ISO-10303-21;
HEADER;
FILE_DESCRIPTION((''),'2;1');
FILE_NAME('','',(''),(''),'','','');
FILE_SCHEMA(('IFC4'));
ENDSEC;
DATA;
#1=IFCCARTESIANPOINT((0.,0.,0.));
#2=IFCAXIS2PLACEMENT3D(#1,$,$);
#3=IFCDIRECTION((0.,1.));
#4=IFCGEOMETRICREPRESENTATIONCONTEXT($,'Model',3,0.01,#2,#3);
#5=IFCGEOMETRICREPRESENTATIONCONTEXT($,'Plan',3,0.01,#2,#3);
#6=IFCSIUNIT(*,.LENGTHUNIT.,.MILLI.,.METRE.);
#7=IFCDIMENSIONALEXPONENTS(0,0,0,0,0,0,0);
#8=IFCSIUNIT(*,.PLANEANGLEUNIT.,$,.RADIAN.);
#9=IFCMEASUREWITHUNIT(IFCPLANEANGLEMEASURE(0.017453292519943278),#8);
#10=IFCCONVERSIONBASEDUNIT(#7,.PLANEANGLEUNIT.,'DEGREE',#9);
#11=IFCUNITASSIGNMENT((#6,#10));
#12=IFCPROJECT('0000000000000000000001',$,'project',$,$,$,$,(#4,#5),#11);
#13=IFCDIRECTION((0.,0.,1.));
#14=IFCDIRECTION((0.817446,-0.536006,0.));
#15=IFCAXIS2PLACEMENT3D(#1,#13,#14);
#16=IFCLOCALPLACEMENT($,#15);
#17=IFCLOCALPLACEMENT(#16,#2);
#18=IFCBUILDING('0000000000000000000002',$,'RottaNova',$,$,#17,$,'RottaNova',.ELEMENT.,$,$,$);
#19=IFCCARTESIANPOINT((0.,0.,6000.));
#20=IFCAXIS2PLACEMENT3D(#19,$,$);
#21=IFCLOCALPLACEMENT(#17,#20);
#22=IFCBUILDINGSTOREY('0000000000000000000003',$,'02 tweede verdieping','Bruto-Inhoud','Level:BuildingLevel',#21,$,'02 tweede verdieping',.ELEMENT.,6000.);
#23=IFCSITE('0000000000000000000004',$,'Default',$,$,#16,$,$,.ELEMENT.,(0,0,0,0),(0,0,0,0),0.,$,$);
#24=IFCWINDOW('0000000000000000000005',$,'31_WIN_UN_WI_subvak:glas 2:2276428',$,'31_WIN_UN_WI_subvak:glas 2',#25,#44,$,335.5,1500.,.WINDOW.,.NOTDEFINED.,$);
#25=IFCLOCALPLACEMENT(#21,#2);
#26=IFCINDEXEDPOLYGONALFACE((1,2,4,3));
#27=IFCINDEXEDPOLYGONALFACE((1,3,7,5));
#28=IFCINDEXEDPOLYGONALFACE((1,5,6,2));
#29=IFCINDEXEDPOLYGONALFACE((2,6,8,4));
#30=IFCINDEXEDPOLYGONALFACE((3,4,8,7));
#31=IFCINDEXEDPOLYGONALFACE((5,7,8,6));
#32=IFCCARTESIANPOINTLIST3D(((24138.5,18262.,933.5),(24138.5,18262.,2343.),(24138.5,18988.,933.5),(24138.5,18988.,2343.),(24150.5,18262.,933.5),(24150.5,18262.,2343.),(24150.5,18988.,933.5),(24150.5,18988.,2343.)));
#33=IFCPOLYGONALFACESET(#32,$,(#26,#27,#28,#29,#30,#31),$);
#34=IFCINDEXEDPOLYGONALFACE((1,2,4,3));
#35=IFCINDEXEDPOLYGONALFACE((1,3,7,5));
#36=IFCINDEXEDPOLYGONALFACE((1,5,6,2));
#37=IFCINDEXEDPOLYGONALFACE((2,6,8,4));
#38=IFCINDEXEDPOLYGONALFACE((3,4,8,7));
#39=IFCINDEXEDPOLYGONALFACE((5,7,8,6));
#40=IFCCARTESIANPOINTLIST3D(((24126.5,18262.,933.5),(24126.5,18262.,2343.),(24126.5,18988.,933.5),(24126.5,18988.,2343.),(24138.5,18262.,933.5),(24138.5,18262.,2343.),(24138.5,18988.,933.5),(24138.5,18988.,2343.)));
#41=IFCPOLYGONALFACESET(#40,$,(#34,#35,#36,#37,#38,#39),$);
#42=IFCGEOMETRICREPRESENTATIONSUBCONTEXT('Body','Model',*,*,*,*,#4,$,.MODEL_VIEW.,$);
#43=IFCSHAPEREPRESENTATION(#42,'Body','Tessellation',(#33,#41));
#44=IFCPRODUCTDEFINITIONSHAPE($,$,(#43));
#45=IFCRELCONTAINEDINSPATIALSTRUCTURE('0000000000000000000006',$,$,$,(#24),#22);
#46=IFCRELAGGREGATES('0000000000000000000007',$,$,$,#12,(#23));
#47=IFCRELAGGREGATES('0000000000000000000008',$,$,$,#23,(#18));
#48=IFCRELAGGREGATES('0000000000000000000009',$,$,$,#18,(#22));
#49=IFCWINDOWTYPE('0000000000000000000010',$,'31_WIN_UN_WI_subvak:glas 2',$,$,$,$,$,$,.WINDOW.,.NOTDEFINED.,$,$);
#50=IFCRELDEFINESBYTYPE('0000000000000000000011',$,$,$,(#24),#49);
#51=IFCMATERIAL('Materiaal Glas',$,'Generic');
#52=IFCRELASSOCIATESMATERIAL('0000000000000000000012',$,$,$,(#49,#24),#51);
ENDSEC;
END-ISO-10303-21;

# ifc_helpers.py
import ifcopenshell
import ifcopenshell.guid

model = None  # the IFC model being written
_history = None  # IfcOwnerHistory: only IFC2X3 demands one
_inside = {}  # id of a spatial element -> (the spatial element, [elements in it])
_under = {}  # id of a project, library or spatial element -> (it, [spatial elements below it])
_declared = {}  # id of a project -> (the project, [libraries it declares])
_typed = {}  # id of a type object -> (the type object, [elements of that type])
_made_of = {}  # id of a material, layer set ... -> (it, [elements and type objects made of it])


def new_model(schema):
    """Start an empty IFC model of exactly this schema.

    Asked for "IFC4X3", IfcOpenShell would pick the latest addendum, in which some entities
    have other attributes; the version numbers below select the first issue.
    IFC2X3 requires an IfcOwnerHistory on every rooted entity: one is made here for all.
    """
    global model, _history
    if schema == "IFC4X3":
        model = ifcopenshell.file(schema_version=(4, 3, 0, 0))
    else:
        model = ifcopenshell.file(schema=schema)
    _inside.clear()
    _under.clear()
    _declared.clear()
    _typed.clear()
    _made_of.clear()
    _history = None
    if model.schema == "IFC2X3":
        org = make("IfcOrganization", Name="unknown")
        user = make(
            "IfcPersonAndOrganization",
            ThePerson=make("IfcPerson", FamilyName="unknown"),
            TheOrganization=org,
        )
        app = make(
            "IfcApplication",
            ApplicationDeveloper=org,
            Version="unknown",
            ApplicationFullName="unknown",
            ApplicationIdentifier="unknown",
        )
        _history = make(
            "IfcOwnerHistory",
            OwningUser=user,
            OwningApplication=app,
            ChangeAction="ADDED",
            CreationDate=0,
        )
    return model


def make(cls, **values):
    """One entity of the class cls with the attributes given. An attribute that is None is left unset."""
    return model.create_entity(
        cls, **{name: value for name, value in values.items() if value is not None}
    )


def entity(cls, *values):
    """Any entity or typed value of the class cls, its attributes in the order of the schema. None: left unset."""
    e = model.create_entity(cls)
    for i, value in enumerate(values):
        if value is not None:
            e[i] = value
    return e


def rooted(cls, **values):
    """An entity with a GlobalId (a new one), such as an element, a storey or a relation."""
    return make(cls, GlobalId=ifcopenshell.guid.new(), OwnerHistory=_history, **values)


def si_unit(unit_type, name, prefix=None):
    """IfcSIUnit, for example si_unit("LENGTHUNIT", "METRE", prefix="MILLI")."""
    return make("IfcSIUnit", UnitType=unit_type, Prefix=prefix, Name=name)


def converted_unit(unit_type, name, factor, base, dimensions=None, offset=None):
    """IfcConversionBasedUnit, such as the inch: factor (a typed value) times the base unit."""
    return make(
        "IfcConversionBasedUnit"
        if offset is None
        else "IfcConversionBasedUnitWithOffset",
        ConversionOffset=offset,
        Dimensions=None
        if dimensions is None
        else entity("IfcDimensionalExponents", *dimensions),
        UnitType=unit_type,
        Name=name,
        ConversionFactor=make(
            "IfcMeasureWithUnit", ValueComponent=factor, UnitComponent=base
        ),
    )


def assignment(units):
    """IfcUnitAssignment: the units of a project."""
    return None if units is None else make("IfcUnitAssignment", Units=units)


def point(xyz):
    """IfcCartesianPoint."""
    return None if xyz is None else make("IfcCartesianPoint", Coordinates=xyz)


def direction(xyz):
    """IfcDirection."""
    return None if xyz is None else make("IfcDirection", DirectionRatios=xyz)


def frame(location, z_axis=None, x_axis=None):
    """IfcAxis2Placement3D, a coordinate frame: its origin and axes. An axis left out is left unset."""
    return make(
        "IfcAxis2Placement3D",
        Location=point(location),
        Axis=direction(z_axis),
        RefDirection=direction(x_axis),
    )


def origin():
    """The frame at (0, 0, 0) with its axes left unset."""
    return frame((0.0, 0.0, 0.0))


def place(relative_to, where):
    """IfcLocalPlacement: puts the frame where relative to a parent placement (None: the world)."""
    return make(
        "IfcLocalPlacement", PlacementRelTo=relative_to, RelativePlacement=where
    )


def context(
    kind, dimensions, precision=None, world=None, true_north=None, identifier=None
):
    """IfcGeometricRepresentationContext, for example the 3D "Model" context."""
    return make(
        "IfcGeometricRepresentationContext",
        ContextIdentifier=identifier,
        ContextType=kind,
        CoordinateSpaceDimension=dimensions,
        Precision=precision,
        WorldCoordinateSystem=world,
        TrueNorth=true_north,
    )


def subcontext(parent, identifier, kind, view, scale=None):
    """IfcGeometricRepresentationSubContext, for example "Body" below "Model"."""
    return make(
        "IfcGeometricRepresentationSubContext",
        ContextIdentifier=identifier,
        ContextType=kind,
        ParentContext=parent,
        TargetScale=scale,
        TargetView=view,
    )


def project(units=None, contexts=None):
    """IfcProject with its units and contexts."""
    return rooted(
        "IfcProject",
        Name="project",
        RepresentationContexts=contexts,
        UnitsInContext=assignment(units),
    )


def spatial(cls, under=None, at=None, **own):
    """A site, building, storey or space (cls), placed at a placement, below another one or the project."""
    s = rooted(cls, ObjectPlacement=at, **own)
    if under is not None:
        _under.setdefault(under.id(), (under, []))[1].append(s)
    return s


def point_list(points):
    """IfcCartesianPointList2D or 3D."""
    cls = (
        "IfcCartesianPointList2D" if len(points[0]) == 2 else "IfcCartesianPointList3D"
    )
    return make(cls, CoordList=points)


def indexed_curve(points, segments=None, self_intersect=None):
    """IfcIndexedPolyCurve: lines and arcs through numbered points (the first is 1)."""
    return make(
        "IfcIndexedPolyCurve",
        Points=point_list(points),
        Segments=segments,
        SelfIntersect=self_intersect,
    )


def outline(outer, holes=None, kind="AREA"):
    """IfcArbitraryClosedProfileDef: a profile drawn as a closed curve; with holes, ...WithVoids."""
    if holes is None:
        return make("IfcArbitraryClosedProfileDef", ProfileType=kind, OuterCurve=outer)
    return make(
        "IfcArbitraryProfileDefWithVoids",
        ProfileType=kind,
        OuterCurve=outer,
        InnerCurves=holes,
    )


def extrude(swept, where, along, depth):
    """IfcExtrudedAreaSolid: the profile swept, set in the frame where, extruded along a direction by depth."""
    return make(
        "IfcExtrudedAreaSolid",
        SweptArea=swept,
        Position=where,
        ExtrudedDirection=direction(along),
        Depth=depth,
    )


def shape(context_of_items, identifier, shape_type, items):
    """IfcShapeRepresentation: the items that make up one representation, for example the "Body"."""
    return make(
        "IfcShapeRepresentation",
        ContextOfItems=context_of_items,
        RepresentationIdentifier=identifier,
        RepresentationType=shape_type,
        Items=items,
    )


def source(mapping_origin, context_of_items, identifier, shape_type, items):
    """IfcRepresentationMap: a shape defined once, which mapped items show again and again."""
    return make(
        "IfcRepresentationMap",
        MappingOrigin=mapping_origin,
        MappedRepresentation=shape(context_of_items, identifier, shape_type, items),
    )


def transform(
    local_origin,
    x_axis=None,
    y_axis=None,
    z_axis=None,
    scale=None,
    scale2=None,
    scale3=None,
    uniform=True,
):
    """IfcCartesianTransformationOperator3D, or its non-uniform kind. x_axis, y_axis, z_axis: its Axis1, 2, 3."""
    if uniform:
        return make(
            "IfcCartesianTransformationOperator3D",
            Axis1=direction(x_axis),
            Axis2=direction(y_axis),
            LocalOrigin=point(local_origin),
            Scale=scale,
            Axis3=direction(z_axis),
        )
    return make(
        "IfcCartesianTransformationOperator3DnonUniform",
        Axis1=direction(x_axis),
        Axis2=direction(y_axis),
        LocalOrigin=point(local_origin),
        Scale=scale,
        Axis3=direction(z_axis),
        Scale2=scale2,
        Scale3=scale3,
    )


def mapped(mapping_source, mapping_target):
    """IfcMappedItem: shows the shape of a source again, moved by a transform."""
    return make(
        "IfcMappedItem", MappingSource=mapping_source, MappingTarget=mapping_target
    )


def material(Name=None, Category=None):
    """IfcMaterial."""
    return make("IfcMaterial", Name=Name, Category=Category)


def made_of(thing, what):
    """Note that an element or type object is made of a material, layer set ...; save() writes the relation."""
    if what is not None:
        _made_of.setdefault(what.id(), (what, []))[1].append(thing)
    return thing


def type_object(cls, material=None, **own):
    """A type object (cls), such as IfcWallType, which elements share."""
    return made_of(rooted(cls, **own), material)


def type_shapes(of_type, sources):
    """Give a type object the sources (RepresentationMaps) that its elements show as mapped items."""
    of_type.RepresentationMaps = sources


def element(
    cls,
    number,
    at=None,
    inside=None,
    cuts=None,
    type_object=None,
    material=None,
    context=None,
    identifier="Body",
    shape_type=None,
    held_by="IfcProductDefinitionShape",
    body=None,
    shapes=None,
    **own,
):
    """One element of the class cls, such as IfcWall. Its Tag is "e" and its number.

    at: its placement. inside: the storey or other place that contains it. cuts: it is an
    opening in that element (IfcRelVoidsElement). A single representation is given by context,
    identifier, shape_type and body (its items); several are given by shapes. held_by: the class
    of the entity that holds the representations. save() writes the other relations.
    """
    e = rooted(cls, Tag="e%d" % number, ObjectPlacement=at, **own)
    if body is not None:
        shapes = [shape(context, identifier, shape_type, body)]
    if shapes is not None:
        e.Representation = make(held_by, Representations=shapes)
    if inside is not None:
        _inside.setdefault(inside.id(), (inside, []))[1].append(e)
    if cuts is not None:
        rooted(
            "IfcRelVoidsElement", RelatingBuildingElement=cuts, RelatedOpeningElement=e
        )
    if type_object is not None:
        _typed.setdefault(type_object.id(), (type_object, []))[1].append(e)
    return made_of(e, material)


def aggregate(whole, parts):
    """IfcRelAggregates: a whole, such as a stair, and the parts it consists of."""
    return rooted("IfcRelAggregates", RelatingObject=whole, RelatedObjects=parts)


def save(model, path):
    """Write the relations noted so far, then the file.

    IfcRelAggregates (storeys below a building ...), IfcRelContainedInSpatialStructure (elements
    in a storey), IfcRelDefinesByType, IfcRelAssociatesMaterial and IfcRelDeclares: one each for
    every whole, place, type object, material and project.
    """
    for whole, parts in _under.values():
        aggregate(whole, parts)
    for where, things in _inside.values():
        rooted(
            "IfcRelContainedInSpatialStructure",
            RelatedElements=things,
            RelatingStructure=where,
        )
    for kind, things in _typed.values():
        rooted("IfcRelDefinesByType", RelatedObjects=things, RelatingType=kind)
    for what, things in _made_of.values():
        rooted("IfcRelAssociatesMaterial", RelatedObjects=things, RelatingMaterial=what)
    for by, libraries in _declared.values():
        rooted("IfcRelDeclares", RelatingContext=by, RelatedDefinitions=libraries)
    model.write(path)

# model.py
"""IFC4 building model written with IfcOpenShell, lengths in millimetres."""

from ifc_helpers import new_model, entity, si_unit, converted_unit, direction, frame, origin, place, context, subcontext, project, spatial, indexed_curve, outline, extrude, source, transform, mapped, material, type_object, type_shapes, element, save


model = new_model("IFC4")

# Units and contexts
model_context = context("Model", 3, precision=0.01, world=origin(), true_north=direction((0.0, 1.0)))
plan_context = context("Plan", 3, precision=0.01, world=origin(), true_north=direction((0.0, 1.0)))
body_context = subcontext(model_context, "Body", "Model", "MODEL_VIEW")
ifc_project = project(units=[si_unit("LENGTHUNIT", "METRE", prefix="MILLI"), converted_unit("PLANEANGLEUNIT", "DEGREE", entity("IfcPlaneAngleMeasure", 0.017453292519943278), si_unit("PLANEANGLEUNIT", "RADIAN"), dimensions=[0, 0, 0, 0, 0, 0, 0])], contexts=[model_context, plan_context])

# Site, building, storey
site_placement = place(None, frame((0.0, 0.0, 0.0), z_axis=(0.0, 0.0, 1.0), x_axis=(0.817446, -0.536006, 0.0)))
site = spatial("IfcSite", under=ifc_project, at=site_placement, Name="Default", CompositionType="ELEMENT", RefLatitude=(0, 0, 0, 0), RefLongitude=(0, 0, 0, 0), RefElevation=0.0)
building_placement = place(site_placement, origin())
building = spatial("IfcBuilding", under=site, at=building_placement, Name="RottaNova", LongName="RottaNova", CompositionType="ELEMENT")
storey_placement = place(building_placement, frame((0.0, 0.0, 6000.0)))
storey = spatial("IfcBuildingStorey", under=building, at=storey_placement, Name="02 tweede verdieping", Description="Bruto-Inhoud", ObjectType="Level:BuildingLevel", LongName="02 tweede verdieping", CompositionType="ELEMENT", Elevation=6000.0)

# Shared definitions
ifc_material_1 = material(Name="Materiaal Glas", Category="Generic")

# Window
window_type_1 = type_object("IfcWindowType", Name="31_WIN_UN_WI_subvak:glas 2", PartitioningType="NOTDEFINED", PredefinedType="WINDOW", material=ifc_material_1)
shared_shape_1 = source(origin(), body_context, "Body", "SweptSolid", [
    extrude(outline(indexed_curve([(-363.0, -6.0), (363.0, -6.0), (363.0, 6.0), (-363.0, 6.0), (-363.0, -6.0)], self_intersect=False)), frame((0.0, -6.0, 0.0)), (0.0, 0.0, 1.0), 1409.5),
    extrude(outline(indexed_curve([(-363.0, -6.0), (363.0, -6.0), (363.0, 6.0), (-363.0, 6.0), (-363.0, -6.0)], self_intersect=False)), frame((0.0, 6.0, 0.0)), (0.0, 0.0, 1.0), 1409.5),
])
type_shapes(window_type_1, [shared_shape_1])
window_1_placement = place(storey_placement, frame((24138.5, 18625.0, 933.5), z_axis=(0.0, 0.0, 1.0), x_axis=(0.0, 1.0, 0.0)))
element("IfcWindow", 1, at=window_1_placement, inside=storey, type_object=window_type_1, material=ifc_material_1, Name="31_WIN_UN_WI_subvak:glas 2:2276428", ObjectType="31_WIN_UN_WI_subvak:glas 2", OverallHeight=335.5, OverallWidth=1500.0, PartitioningType="NOTDEFINED", PredefinedType="WINDOW", context=body_context, shape_type="MappedRepresentation", body=[
    mapped(shared_shape_1, transform((0.0, 0.0, 0.0), scale=1.0)),
])

save(model, "model.ifc")
